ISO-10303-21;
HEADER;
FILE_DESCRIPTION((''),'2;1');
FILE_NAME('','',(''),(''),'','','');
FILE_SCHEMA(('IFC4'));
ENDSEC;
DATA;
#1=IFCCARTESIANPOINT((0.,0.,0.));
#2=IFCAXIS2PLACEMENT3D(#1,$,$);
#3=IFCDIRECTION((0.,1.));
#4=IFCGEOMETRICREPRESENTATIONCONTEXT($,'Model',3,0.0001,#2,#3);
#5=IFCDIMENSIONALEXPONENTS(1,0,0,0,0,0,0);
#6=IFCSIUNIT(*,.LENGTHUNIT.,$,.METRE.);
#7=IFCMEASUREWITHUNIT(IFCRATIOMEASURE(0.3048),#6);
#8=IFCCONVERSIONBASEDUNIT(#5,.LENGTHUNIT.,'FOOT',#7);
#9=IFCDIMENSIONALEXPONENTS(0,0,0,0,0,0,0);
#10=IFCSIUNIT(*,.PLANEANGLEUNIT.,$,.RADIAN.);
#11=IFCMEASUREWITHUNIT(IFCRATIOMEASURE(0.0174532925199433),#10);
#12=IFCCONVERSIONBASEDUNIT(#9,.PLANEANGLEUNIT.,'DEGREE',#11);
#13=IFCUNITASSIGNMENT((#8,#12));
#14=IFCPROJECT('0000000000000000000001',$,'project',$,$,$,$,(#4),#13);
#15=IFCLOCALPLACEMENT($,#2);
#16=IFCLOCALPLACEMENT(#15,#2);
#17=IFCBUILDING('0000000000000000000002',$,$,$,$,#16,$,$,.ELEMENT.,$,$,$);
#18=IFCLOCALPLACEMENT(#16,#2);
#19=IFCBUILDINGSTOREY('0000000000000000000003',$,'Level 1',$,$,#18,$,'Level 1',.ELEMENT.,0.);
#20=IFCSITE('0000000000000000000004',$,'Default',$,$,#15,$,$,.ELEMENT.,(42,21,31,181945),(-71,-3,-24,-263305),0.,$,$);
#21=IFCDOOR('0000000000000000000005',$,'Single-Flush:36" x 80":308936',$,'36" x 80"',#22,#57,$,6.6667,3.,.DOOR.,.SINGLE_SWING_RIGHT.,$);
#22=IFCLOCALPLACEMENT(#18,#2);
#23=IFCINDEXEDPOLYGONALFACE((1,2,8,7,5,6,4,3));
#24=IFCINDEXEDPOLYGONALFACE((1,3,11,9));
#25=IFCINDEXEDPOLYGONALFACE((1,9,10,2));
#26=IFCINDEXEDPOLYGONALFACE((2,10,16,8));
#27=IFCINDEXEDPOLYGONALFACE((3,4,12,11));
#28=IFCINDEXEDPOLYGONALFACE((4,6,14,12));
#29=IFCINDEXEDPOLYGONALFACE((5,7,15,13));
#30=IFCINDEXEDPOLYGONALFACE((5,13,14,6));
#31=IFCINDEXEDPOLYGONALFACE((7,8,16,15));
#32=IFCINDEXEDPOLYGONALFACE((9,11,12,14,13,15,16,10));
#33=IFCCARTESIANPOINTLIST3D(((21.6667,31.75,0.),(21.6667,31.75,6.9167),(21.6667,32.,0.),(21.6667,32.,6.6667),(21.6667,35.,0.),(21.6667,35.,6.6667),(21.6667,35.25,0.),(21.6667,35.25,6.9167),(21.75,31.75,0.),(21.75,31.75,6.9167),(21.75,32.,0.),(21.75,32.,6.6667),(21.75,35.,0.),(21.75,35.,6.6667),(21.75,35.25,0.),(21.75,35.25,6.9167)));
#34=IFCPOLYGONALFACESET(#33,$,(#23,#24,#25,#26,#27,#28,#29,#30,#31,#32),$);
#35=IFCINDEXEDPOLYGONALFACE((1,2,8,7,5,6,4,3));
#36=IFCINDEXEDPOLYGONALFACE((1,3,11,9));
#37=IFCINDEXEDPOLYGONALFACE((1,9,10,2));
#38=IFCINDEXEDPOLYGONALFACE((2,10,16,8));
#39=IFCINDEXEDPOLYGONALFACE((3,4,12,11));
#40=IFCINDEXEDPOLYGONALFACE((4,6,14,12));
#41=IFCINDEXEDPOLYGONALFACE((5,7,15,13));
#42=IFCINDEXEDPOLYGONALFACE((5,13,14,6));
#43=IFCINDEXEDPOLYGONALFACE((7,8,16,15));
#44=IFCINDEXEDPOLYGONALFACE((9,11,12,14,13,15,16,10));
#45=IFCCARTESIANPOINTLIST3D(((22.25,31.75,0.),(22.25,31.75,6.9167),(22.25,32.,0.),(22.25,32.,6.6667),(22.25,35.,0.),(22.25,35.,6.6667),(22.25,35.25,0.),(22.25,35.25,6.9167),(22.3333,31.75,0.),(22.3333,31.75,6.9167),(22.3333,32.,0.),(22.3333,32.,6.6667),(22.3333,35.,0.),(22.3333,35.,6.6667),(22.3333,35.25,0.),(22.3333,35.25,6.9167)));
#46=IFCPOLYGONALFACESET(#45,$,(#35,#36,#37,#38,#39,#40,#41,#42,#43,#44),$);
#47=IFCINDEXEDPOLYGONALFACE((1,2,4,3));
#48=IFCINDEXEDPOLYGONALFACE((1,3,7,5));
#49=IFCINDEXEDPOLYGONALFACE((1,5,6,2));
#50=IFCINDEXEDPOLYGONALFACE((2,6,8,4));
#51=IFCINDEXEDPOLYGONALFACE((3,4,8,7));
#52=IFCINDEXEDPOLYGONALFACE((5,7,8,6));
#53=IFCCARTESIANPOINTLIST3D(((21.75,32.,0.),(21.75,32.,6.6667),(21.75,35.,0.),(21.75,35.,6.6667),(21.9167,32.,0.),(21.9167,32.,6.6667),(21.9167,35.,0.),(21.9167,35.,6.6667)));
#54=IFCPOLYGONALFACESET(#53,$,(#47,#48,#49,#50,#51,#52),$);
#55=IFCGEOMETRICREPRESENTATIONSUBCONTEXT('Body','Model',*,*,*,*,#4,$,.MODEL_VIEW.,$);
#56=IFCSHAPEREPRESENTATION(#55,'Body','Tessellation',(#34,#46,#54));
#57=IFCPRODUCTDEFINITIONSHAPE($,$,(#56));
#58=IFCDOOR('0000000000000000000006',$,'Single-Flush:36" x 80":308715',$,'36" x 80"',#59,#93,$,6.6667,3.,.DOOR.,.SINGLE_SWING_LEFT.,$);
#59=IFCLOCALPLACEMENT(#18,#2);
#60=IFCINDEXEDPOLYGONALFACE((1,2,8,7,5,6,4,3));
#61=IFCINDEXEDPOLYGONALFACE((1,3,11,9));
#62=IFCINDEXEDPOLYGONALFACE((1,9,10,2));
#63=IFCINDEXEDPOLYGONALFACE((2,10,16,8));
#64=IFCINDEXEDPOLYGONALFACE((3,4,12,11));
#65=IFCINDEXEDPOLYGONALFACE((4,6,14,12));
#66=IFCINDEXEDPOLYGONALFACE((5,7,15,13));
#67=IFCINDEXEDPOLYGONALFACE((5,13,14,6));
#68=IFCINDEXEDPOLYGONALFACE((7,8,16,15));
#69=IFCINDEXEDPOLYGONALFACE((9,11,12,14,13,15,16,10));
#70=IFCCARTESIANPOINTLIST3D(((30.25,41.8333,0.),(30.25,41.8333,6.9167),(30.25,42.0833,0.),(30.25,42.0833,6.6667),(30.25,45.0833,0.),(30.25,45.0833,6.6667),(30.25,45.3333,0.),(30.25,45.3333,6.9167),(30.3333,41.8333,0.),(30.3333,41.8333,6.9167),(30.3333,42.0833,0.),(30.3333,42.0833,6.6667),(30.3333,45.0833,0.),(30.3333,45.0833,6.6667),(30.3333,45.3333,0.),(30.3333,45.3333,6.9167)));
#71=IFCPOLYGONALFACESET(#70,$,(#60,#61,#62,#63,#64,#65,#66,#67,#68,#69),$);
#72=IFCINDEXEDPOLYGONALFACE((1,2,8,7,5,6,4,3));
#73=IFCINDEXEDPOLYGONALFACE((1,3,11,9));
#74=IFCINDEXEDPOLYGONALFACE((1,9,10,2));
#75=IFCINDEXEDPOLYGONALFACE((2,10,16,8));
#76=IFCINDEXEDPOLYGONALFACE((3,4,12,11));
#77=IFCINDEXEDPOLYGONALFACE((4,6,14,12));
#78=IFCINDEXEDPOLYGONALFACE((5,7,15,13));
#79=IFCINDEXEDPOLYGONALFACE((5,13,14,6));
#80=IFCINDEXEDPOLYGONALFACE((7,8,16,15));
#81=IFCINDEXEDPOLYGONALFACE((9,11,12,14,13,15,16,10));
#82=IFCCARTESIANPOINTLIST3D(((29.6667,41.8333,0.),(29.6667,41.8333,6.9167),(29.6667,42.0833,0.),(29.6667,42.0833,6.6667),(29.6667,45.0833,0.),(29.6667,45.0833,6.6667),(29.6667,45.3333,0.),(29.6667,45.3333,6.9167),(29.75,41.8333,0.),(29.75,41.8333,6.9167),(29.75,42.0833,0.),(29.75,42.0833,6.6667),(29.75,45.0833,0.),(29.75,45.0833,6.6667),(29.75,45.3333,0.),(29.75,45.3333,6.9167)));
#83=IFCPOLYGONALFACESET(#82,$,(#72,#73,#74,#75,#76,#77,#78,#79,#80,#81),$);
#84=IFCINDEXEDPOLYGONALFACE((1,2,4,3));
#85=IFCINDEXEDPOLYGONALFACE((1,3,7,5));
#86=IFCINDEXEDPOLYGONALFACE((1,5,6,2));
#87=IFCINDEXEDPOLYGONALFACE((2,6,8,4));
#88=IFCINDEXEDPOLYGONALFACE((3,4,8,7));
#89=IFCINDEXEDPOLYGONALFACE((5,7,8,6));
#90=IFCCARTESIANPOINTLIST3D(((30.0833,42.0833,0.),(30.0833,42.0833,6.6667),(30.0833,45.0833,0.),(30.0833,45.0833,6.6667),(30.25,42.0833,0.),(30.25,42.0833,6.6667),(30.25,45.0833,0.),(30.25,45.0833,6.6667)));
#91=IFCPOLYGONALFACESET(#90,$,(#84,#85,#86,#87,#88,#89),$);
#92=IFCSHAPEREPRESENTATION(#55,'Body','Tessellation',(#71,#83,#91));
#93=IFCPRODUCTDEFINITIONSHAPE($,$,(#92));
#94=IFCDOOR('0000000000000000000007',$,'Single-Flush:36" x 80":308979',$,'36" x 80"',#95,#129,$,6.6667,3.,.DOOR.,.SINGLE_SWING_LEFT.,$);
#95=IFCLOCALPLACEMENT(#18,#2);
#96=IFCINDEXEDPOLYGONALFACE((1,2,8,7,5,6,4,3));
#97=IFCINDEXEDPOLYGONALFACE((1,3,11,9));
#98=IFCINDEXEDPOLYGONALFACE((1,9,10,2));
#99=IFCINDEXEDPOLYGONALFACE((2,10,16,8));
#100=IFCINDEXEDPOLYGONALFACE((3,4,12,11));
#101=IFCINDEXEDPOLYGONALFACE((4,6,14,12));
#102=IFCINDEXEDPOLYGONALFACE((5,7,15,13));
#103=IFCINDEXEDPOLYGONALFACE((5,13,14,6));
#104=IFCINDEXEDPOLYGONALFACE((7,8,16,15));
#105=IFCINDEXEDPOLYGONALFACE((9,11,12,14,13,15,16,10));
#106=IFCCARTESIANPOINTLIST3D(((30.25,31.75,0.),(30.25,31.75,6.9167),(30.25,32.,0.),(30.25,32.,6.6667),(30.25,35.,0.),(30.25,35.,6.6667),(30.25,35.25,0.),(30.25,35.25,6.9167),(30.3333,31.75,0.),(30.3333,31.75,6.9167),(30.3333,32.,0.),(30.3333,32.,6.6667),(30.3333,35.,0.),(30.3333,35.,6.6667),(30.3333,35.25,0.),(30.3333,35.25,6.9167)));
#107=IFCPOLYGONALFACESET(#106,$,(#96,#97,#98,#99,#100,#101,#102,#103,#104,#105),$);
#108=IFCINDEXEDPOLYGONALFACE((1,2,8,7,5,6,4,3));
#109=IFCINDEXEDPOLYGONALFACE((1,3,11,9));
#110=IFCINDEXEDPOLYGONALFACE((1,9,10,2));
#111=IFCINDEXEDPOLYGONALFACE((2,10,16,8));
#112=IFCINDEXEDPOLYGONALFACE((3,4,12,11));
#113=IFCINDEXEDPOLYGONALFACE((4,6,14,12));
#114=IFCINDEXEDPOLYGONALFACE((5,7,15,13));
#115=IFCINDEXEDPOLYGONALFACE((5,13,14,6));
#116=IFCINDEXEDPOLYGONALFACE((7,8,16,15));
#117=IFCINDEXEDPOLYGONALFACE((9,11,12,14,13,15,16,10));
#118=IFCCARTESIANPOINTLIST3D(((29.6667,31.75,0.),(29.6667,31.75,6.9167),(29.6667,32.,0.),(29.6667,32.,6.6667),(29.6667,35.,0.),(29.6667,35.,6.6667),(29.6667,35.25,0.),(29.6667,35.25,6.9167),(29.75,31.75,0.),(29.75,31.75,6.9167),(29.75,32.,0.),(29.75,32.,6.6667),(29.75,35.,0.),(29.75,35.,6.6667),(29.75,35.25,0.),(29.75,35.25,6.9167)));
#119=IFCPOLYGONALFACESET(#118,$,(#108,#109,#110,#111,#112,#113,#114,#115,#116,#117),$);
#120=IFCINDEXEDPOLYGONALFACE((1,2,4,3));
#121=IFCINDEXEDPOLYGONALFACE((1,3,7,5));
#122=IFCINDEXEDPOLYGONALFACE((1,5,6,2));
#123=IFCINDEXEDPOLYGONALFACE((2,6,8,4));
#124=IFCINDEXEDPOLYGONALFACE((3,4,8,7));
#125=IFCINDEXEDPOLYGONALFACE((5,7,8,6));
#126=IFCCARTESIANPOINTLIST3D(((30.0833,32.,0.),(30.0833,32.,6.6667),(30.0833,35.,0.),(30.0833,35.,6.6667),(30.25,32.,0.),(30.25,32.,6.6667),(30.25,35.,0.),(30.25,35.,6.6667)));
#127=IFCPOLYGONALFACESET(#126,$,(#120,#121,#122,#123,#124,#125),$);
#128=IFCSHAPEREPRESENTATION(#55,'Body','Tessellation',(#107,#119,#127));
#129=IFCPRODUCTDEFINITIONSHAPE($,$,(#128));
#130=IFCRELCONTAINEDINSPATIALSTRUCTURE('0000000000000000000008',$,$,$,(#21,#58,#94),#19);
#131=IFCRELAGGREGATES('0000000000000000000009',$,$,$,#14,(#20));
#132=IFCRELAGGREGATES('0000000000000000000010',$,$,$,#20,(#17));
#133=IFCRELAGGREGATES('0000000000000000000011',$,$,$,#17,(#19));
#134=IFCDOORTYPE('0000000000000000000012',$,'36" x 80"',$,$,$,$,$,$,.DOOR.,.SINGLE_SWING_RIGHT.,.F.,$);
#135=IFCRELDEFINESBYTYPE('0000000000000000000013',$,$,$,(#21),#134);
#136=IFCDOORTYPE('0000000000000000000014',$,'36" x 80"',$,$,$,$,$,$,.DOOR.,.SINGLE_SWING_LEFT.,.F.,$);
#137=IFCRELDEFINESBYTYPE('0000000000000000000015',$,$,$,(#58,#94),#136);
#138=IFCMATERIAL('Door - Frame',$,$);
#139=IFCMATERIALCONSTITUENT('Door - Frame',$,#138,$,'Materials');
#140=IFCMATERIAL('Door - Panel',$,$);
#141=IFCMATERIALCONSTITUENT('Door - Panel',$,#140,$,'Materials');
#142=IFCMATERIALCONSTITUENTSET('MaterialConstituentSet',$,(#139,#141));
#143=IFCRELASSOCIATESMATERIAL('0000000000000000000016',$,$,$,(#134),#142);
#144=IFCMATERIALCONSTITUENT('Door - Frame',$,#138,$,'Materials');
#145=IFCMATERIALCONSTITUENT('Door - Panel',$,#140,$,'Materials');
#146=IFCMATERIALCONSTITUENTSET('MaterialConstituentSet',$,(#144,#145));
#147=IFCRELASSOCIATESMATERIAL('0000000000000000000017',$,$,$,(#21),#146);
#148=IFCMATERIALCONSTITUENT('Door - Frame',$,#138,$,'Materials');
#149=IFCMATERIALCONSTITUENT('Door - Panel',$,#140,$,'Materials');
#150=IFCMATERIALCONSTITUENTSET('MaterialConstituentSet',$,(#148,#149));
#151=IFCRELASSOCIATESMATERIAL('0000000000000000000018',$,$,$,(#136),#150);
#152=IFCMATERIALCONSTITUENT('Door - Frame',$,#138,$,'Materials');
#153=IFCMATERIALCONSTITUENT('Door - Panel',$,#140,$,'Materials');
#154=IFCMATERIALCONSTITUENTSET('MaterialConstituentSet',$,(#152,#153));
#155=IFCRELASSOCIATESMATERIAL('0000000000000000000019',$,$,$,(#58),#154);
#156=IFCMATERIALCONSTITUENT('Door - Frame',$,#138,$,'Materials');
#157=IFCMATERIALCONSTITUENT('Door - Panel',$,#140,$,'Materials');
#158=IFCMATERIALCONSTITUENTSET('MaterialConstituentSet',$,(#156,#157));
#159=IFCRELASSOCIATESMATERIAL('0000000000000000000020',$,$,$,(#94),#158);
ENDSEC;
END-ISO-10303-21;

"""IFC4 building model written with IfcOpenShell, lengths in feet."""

from ifc_helpers import new_model, entity, si_unit, converted_unit, direction, frame, origin, origin_2d_with_axis, place, context, subcontext, project, spatial, polyline, rectangle, outline, extrude, source, transform, mapped, material, constituent, constituent_set, type_object, type_shapes, element, save


model = new_model("IFC4")

# Units and contexts
model_context = context("Model", 3, precision=0.0001, world=origin(), true_north=direction((0.0, 1.0)))
body_context = subcontext(model_context, "Body", "Model", "MODEL_VIEW")
ifc_project = project(units=[converted_unit("LENGTHUNIT", "FOOT", entity("IfcRatioMeasure", 0.3048), si_unit("LENGTHUNIT", "METRE"), dimensions=[1, 0, 0, 0, 0, 0, 0]), converted_unit("PLANEANGLEUNIT", "DEGREE", entity("IfcRatioMeasure", 0.0174532925199433), si_unit("PLANEANGLEUNIT", "RADIAN"), dimensions=[0, 0, 0, 0, 0, 0, 0])], contexts=[model_context])

# Site, building, storey
site_placement = place(None, origin())
site = spatial("IfcSite", under=ifc_project, at=site_placement, Name="Default", CompositionType="ELEMENT", RefLatitude=(42, 21, 31, 181945), RefLongitude=(-71, -3, -24, -263305), RefElevation=0.0)
building_placement = place(site_placement, origin())
building = spatial("IfcBuilding", under=site, at=building_placement, CompositionType="ELEMENT")
storey_placement = place(building_placement, origin())
storey = spatial("IfcBuildingStorey", under=building, at=storey_placement, Name="Level 1", LongName="Level 1", CompositionType="ELEMENT", Elevation=0.0)

# Shared definitions
placement_1 = place(storey_placement, frame((30.0, 45.75, 0.0), z_axis=(0.0, 0.0, 1.0), x_axis=(0.0, -1.0, 0.0)))
placement_2 = place(storey_placement, frame((22.0, 45.75, 0.0), z_axis=(0.0, 0.0, 1.0), x_axis=(0.0, -1.0, 0.0)))

# Doors
ifc_material_1 = material(Name="Door - Frame")
ifc_material_2 = material(Name="Door - Panel")
ifc_constituent_1 = constituent(ifc_material_1, Name="Door - Frame", Category="Materials")
ifc_constituent_2 = constituent(ifc_material_2, Name="Door - Panel", Category="Materials")
ifc_constituent_set_1 = constituent_set(constituents=[ifc_constituent_1, ifc_constituent_2], Name="MaterialConstituentSet")
door_type_1 = type_object("IfcDoorType", Name="36\" x 80\"", OperationType="SINGLE_SWING_RIGHT", ParameterTakesPrecedence=False, PredefinedType="DOOR", material=ifc_constituent_set_1)
shared_shape_1 = source(origin(), body_context, "Body", "SweptSolid", [
    extrude(outline(polyline([(-1.75, -3.5208), (1.75, -3.5208), (1.75, 3.3958), (1.5, 3.3958), (1.5, -3.2708), (-1.5, -3.2708), (-1.5, 3.3958), (-1.75, 3.3958), (-1.75, -3.5208)])), frame((1.5, 0.5, 3.3958), z_axis=(0.0, 1.0, 0.0), x_axis=(1.0, 0.0, 0.0)), (0.0, 0.0, 1.0), 0.0833),
    extrude(outline(polyline([(-3.5208, -1.75), (3.3958, -1.75), (3.3958, -1.5), (-3.2708, -1.5), (-3.2708, 1.5), (3.3958, 1.5), (3.3958, 1.75), (-3.5208, 1.75), (-3.5208, -1.75)])), frame((1.5, -0.0833, 3.3958), z_axis=(0.0, 1.0, 0.0), x_axis=(0.0, 0.0, -1.0)), (0.0, 0.0, 1.0), 0.0833),
    extrude(rectangle(XDim=0.1667, YDim=3.0, at=origin_2d_with_axis()), frame((1.5, 0.4167, 0.0), z_axis=(0.0, 0.0, 1.0), x_axis=(0.0, 1.0, 0.0)), (0.0, 0.0, 1.0), 6.6667),
])
type_shapes(door_type_1, [shared_shape_1])
ifc_constituent_3 = constituent(ifc_material_1, Name="Door - Frame", Category="Materials")
ifc_constituent_4 = constituent(ifc_material_2, Name="Door - Panel", Category="Materials")
ifc_constituent_set_2 = constituent_set(constituents=[ifc_constituent_3, ifc_constituent_4], Name="MaterialConstituentSet")
placement_3 = place(placement_2, frame((13.75, 0.25, 0.0)))
door_1_placement = place(placement_3, frame((0.0, 0.0, 0.0), z_axis=(0.0, 0.0, 1.0), x_axis=(-1.0, 0.0, 0.0)))
element("IfcDoor", 1, at=door_1_placement, inside=storey, type_object=door_type_1, material=ifc_constituent_set_2, Name="Single-Flush:36\" x 80\":308936", ObjectType="36\" x 80\"", OperationType="SINGLE_SWING_RIGHT", OverallHeight=6.6667, OverallWidth=3.0, PredefinedType="DOOR", context=body_context, shape_type="MappedRepresentation", body=[
    mapped(shared_shape_1, transform((0.0, 0.0, 0.0), scale=1.0)),
])
ifc_constituent_5 = constituent(ifc_material_1, Name="Door - Frame", Category="Materials")
ifc_constituent_6 = constituent(ifc_material_2, Name="Door - Panel", Category="Materials")
ifc_constituent_set_3 = constituent_set(constituents=[ifc_constituent_5, ifc_constituent_6], Name="MaterialConstituentSet")
ifc_constituent_7 = constituent(ifc_material_1, Name="Door - Frame", Category="Materials")
ifc_constituent_8 = constituent(ifc_material_2, Name="Door - Panel", Category="Materials")
ifc_constituent_set_4 = constituent_set(constituents=[ifc_constituent_7, ifc_constituent_8], Name="MaterialConstituentSet")
door_type_2 = type_object("IfcDoorType", Name="36\" x 80\"", OperationType="SINGLE_SWING_LEFT", ParameterTakesPrecedence=False, PredefinedType="DOOR", material=ifc_constituent_set_4)
shared_shape_2 = source(origin(), body_context, "Body", "SweptSolid", [
    extrude(outline(polyline([(-1.75, -3.5208), (1.75, -3.5208), (1.75, 3.3958), (1.5, 3.3958), (1.5, -3.2708), (-1.5, -3.2708), (-1.5, 3.3958), (-1.75, 3.3958), (-1.75, -3.5208)])), frame((1.5, 0.5833, 3.3958), z_axis=(0.0, -1.0, 0.0), x_axis=(-1.0, 0.0, 0.0)), (0.0, 0.0, 1.0), 0.0833),
    extrude(outline(polyline([(-3.5208, -1.75), (3.3958, -1.75), (3.3958, -1.5), (-3.2708, -1.5), (-3.2708, 1.5), (3.3958, 1.5), (3.3958, 1.75), (-3.5208, 1.75), (-3.5208, -1.75)])), frame((1.5, 0.0, 3.3958), z_axis=(0.0, -1.0, 0.0), x_axis=(0.0, 0.0, -1.0)), (0.0, 0.0, 1.0), 0.0833),
    extrude(rectangle(XDim=3.0, YDim=0.1667, at=origin_2d_with_axis()), frame((1.5, 0.4167, 0.0)), (0.0, 0.0, 1.0), 6.6667),
])
type_shapes(door_type_2, [shared_shape_2])
placement_4 = place(placement_1, frame((0.6667, -0.25, 0.0)))
door_2_placement = place(placement_4, origin())
element("IfcDoor", 2, at=door_2_placement, inside=storey, type_object=door_type_2, material=ifc_constituent_set_3, Name="Single-Flush:36\" x 80\":308715", ObjectType="36\" x 80\"", OperationType="SINGLE_SWING_LEFT", OverallHeight=6.6667, OverallWidth=3.0, PredefinedType="DOOR", context=body_context, shape_type="MappedRepresentation", body=[
    mapped(shared_shape_2, transform((0.0, 0.0, 0.0), scale=1.0)),
])
ifc_constituent_9 = constituent(ifc_material_1, Name="Door - Frame", Category="Materials")
ifc_constituent_10 = constituent(ifc_material_2, Name="Door - Panel", Category="Materials")
ifc_constituent_set_5 = constituent_set(constituents=[ifc_constituent_9, ifc_constituent_10], Name="MaterialConstituentSet")
placement_5 = place(placement_1, frame((10.75, -0.25, 0.0)))
door_3_placement = place(placement_5, origin())
element("IfcDoor", 3, at=door_3_placement, inside=storey, type_object=door_type_2, material=ifc_constituent_set_5, Name="Single-Flush:36\" x 80\":308979", ObjectType="36\" x 80\"", OperationType="SINGLE_SWING_LEFT", OverallHeight=6.6667, OverallWidth=3.0, PredefinedType="DOOR", context=body_context, shape_type="MappedRepresentation", body=[
    mapped(shared_shape_2, transform((0.0, 0.0, 0.0), scale=1.0)),
])

save(model, "model.ifc")
